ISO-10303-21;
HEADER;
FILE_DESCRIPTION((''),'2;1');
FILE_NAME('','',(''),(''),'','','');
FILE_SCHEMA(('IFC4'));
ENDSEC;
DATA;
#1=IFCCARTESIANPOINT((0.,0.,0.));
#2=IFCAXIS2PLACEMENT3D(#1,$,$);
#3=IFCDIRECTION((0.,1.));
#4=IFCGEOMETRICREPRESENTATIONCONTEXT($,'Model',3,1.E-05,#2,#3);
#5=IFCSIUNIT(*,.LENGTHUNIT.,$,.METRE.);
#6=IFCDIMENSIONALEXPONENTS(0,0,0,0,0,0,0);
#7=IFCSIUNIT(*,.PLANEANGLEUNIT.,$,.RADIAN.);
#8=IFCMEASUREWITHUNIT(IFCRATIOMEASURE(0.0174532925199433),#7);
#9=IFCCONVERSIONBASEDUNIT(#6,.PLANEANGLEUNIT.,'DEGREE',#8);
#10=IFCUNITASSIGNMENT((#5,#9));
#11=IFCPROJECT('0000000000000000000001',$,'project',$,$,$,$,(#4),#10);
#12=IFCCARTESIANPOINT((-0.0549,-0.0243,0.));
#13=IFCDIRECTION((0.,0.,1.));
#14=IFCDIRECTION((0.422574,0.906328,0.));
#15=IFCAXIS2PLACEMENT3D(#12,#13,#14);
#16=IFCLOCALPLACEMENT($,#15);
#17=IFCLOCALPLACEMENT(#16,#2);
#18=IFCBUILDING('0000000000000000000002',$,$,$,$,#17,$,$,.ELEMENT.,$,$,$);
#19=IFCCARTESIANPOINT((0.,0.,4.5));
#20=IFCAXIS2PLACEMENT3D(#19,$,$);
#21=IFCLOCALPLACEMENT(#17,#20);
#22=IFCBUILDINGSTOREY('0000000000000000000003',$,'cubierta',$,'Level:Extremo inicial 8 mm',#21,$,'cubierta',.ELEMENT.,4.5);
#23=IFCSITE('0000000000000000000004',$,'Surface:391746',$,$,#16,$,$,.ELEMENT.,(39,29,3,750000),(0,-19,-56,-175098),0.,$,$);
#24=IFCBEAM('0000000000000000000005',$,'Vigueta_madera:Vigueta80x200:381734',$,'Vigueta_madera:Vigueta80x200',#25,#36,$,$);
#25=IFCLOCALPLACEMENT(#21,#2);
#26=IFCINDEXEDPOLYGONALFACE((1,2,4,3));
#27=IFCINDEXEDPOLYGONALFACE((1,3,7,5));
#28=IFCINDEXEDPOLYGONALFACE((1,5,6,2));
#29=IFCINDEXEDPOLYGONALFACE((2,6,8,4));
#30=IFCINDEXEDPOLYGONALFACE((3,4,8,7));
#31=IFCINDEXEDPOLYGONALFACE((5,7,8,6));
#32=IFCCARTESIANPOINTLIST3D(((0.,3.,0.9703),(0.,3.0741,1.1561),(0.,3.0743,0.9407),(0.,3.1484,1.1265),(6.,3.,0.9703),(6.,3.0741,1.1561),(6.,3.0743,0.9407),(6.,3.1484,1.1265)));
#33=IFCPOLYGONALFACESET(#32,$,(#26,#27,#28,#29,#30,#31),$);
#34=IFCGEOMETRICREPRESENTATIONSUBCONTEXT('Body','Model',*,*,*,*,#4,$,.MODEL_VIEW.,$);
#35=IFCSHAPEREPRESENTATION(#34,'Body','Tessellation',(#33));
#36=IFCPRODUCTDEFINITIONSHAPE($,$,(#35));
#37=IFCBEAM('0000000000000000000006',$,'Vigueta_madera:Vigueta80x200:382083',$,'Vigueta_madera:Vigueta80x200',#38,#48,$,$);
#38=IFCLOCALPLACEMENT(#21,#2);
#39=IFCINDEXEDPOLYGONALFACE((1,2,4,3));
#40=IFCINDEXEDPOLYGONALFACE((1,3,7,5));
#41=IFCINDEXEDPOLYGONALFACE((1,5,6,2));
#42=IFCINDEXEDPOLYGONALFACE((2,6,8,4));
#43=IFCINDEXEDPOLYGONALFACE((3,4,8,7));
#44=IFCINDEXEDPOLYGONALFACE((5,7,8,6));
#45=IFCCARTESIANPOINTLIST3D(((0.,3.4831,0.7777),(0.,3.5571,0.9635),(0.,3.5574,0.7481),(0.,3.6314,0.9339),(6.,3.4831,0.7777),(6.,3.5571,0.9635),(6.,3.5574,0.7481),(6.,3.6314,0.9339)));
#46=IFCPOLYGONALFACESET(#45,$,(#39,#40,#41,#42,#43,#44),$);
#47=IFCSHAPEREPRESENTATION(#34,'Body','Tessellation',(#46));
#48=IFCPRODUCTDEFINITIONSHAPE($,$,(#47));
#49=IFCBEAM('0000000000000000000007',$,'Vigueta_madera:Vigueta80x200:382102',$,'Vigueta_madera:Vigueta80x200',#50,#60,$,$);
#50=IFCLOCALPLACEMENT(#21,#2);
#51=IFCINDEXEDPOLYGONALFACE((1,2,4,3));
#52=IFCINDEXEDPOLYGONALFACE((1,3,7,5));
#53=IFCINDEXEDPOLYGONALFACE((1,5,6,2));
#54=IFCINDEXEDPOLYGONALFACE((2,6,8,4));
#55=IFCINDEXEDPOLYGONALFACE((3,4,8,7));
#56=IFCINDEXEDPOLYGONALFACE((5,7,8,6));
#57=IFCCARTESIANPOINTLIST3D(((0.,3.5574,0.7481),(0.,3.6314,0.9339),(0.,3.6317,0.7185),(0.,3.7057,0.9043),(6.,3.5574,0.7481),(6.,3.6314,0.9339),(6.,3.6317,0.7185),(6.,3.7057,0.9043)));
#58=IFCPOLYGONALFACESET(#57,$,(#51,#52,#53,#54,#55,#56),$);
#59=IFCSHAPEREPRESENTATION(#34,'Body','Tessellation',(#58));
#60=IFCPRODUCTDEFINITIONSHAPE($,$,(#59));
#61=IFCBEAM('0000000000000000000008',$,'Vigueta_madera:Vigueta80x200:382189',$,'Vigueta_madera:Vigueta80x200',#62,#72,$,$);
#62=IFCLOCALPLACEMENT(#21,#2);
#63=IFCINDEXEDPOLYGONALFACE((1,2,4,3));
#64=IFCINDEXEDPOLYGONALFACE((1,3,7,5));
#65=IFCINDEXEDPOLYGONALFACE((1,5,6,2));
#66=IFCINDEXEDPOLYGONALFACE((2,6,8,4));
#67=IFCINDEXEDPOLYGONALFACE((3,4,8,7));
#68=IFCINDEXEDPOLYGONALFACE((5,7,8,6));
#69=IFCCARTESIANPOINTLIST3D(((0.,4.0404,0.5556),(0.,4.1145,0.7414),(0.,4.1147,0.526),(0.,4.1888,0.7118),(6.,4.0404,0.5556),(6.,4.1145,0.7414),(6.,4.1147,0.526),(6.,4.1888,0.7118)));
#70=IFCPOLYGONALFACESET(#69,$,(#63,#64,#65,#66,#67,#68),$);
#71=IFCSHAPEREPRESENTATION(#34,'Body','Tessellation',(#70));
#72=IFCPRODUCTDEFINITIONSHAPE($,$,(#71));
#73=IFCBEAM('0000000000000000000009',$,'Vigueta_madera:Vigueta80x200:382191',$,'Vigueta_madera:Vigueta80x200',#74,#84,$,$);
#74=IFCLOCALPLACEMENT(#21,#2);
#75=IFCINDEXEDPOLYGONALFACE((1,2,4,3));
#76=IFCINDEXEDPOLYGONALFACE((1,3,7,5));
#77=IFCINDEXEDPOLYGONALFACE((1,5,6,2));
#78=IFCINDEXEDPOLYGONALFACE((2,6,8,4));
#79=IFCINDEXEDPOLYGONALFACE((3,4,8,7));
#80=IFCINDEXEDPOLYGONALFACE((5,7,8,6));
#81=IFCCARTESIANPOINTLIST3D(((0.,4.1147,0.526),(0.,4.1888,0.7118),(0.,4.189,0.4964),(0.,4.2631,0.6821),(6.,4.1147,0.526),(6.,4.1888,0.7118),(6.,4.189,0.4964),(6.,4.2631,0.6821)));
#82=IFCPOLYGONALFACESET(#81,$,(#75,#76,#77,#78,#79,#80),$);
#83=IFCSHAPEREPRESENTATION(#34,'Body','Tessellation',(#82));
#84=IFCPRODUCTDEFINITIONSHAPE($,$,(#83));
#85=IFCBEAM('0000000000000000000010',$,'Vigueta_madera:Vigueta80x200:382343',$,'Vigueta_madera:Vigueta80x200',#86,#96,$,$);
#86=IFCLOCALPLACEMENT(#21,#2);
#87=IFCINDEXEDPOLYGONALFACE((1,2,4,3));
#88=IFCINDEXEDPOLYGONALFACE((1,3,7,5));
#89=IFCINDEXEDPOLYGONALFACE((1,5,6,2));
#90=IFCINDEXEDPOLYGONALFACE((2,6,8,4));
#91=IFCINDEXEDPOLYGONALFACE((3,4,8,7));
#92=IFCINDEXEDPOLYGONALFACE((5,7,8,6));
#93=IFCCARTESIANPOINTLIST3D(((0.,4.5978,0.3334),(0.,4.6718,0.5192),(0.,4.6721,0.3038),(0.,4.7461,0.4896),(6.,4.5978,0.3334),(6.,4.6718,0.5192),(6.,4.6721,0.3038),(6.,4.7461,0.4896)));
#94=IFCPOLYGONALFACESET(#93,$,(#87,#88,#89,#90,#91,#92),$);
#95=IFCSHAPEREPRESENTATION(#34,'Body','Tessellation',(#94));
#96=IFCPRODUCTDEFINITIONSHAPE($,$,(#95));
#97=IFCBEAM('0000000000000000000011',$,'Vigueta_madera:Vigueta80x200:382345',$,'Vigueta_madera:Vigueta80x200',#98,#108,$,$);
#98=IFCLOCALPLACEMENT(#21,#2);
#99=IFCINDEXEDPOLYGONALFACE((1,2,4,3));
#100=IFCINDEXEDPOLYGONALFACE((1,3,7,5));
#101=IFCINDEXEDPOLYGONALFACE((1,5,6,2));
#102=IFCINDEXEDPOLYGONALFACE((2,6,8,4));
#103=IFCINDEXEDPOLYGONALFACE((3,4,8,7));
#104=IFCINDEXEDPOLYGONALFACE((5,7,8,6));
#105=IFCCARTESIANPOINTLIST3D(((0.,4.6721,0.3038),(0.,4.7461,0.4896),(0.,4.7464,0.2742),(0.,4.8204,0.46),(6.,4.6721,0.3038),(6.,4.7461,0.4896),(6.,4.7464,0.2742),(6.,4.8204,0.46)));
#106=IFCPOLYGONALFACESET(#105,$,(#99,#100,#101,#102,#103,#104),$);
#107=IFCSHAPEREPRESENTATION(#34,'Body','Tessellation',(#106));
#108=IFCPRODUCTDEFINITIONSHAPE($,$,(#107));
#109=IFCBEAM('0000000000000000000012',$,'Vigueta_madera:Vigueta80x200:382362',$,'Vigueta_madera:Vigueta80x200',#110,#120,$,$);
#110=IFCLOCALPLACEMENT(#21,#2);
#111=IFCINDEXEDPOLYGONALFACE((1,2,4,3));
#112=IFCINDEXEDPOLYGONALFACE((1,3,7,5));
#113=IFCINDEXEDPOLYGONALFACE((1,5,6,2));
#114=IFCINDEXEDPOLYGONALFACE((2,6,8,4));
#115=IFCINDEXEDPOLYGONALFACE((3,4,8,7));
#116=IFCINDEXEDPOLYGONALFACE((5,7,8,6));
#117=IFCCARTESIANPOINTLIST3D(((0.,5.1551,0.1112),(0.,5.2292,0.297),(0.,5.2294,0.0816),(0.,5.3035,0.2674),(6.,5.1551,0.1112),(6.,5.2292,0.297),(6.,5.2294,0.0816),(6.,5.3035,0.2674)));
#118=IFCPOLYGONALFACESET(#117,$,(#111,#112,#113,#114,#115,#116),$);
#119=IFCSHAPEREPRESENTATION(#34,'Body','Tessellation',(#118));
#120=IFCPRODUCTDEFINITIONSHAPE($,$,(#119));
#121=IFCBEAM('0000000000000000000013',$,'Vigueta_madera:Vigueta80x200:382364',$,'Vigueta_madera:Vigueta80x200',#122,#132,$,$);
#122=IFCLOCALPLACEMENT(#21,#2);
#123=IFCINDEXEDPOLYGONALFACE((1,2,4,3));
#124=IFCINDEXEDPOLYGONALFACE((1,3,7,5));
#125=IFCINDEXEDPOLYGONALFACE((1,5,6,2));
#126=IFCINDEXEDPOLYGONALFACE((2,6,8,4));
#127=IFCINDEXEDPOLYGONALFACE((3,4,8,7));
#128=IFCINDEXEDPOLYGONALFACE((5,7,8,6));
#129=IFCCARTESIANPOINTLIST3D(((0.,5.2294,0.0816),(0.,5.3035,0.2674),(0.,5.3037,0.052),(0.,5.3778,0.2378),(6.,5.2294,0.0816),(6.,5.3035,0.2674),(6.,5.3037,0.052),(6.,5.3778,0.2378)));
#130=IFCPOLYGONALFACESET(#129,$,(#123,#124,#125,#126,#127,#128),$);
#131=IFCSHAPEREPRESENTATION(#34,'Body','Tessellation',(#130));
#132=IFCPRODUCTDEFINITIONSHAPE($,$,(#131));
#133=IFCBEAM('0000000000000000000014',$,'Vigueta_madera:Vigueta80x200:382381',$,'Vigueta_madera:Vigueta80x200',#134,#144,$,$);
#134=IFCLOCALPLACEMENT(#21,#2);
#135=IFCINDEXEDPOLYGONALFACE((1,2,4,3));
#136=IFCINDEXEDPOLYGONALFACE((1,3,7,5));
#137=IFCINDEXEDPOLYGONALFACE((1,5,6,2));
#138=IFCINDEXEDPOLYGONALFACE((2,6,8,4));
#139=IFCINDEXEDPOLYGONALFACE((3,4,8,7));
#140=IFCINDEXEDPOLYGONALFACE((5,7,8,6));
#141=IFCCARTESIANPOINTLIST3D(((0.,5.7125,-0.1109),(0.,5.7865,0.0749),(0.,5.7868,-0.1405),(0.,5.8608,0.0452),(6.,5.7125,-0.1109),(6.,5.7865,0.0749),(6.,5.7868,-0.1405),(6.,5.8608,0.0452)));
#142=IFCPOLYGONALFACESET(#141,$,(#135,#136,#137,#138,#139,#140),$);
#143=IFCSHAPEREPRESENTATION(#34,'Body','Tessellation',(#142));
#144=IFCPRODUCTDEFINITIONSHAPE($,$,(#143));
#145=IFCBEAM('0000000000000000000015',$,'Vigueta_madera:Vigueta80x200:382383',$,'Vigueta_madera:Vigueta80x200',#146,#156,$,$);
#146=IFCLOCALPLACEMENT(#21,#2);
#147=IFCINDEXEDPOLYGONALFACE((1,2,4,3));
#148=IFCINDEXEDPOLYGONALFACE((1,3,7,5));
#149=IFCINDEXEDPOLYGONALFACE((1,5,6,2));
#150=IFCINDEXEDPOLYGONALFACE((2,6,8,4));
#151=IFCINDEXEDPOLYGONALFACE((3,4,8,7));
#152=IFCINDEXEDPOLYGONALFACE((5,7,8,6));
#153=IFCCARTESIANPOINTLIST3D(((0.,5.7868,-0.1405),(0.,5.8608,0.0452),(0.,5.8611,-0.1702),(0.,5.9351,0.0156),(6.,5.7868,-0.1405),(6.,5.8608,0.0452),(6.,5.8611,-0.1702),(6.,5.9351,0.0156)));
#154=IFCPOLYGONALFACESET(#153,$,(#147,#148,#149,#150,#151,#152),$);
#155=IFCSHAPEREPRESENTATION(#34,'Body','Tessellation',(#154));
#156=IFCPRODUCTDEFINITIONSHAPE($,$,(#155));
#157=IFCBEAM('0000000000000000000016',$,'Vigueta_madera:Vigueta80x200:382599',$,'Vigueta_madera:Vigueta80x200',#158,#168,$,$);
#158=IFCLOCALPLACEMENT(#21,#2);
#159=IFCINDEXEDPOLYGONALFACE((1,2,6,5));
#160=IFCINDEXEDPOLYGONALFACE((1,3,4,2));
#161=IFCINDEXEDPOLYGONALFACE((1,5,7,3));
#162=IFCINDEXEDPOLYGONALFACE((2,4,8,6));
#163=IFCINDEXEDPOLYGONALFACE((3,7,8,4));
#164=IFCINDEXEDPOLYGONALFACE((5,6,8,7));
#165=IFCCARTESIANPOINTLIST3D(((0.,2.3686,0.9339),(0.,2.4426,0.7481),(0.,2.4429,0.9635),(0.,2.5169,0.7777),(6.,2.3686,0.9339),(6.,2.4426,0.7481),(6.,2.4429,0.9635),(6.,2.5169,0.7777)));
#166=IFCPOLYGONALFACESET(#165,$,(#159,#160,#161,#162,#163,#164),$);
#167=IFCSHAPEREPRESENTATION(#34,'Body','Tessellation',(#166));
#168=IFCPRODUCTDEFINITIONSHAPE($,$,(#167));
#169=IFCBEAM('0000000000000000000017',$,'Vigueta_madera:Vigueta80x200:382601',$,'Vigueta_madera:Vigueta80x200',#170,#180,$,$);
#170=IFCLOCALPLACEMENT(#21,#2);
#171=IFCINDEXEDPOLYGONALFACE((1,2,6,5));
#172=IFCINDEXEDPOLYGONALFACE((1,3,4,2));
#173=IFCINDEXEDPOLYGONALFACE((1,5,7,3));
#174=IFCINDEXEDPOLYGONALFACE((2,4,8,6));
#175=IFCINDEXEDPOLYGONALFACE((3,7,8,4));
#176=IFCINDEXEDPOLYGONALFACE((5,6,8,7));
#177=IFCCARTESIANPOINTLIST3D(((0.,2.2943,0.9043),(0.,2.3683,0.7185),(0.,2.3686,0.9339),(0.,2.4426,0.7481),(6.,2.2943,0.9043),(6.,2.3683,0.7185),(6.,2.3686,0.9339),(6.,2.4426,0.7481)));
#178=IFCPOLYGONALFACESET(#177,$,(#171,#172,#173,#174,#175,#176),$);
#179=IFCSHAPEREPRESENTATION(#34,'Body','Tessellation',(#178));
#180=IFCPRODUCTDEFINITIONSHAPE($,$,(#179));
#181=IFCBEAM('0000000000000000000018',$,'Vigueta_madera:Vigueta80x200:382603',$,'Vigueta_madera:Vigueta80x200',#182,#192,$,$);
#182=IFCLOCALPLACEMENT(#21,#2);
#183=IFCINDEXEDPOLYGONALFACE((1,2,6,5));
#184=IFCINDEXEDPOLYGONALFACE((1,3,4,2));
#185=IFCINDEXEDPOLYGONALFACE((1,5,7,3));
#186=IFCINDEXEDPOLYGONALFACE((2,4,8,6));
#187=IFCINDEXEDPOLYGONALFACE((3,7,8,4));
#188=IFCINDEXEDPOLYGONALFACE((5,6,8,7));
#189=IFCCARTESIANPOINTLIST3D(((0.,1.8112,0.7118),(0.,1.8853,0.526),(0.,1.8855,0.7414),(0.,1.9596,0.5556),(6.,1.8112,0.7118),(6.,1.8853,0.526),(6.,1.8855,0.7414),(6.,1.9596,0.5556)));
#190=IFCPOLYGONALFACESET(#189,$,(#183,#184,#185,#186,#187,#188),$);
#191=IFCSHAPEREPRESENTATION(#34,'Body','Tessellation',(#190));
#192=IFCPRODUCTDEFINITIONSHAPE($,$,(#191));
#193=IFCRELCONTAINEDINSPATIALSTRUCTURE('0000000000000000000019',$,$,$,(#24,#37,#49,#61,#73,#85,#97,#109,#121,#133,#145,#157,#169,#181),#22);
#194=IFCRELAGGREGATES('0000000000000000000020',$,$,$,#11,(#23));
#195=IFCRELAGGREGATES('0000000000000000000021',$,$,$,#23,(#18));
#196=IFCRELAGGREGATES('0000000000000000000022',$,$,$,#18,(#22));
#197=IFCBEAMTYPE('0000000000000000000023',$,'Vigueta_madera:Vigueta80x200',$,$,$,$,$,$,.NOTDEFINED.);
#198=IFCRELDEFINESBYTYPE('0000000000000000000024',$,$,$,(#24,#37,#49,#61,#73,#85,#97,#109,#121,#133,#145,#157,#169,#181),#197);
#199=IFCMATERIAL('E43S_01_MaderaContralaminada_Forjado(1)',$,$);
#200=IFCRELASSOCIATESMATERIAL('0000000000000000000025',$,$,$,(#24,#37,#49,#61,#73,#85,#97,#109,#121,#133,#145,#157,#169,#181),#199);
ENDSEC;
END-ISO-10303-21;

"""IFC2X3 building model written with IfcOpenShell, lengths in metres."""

from ifc_helpers import new_model, entity, si_unit, converted_unit, direction, frame, frame_2d, origin, place, context, subcontext, project, spatial, rectangle, extrude, material, type_object, element, save


model = new_model("IFC2X3")

# Units and contexts
model_context = context("Model", 3, precision=1e-05, world=origin(), true_north=direction((0.0, 1.0)))
body_context = subcontext(model_context, "Body", "Model", "MODEL_VIEW")
ifc_project = project(units=[si_unit("LENGTHUNIT", "METRE"), converted_unit("PLANEANGLEUNIT", "DEGREE", entity("IfcRatioMeasure", 0.0174532925199433), si_unit("PLANEANGLEUNIT", "RADIAN"), dimensions=[0, 0, 0, 0, 0, 0, 0])], contexts=[model_context])

# Site, building, storey
site_placement = place(None, frame((-0.0549, -0.0243, 0.0), z_axis=(0.0, 0.0, 1.0), x_axis=(0.422574, 0.906328, 0.0)))
site = spatial("IfcSite", under=ifc_project, at=site_placement, Name="Surface:391746", CompositionType="ELEMENT", RefLatitude=(39, 29, 3, 750000), RefLongitude=(0, -19, -56, -175098), RefElevation=0.0)
building_placement = place(site_placement, origin())
building = spatial("IfcBuilding", under=site, at=building_placement, CompositionType="ELEMENT")
storey_placement = place(building_placement, frame((0.0, 0.0, 4.5)))
storey = spatial("IfcBuildingStorey", under=building, at=storey_placement, Name="cubierta", ObjectType="Level:Extremo inicial 8 mm", LongName="cubierta", CompositionType="ELEMENT", Elevation=4.5)

# Beams
ifc_material_1 = material(Name="E43S_01_MaderaContralaminada_Forjado(1)")
beam_type = type_object("IfcBeamType", Name="Vigueta_madera:Vigueta80x200", PredefinedType="NOTDEFINED")
beam_1_placement = place(storey_placement, frame((0.0, 3.1112, 1.1413)))
element("IfcBeam", 1, at=beam_1_placement, inside=storey, type_object=beam_type, material=ifc_material_1, Name="Vigueta_madera:Vigueta80x200:381734", ObjectType="Vigueta_madera:Vigueta80x200", context=body_context, shape_type="SweptSolid", body=[
    extrude(rectangle(XDim=0.2, YDim=0.08, at=frame_2d((0.0, 0.0), x_axis=(0.0, 1.0))), frame((0.0, -0.037, -0.0929), z_axis=(1.0, 0.0, 0.0), x_axis=(0.0, -0.928939, 0.370233)), (0.0, 0.0, 1.0), 6.0),
])
beam_2_placement = place(storey_placement, frame((0.0, 3.5943, 0.9487)))
element("IfcBeam", 2, at=beam_2_placement, inside=storey, type_object=beam_type, material=ifc_material_1, Name="Vigueta_madera:Vigueta80x200:382083", ObjectType="Vigueta_madera:Vigueta80x200", context=body_context, shape_type="SweptSolid", body=[
    extrude(rectangle(XDim=0.2, YDim=0.08, at=frame_2d((0.0, 0.0), x_axis=(0.0, 1.0))), frame((0.0, -0.037, -0.0929), z_axis=(1.0, 0.0, 0.0), x_axis=(0.0, -0.928939, 0.370233)), (0.0, 0.0, 1.0), 6.0),
])
for number, where, name in (
    (3, (0.0, 3.6686, 0.9191), "Vigueta_madera:Vigueta80x200:382102"),
    (4, (0.0, 4.1516, 0.7266), "Vigueta_madera:Vigueta80x200:382189"),
):
    element("IfcBeam", number, at=place(storey_placement, frame(where)), inside=storey, type_object=beam_type, material=ifc_material_1, Name=name, ObjectType="Vigueta_madera:Vigueta80x200", context=body_context, shape_type="SweptSolid", body=[
        extrude(rectangle(XDim=0.2, YDim=0.08, at=frame_2d((0.0, 0.0), x_axis=(0.0, 1.0))), frame((0.0, -0.037, -0.0929), z_axis=(1.0, 0.0, 0.0), x_axis=(0.0, -0.928939, 0.370233)), (0.0, 0.0, 1.0), 6.0),
    ])
beam_3_placement = place(storey_placement, frame((0.0, 4.2259, 0.697)))
element("IfcBeam", 5, at=beam_3_placement, inside=storey, type_object=beam_type, material=ifc_material_1, Name="Vigueta_madera:Vigueta80x200:382191", ObjectType="Vigueta_madera:Vigueta80x200", context=body_context, shape_type="SweptSolid", body=[
    extrude(rectangle(XDim=0.2, YDim=0.08, at=frame_2d((0.0, 0.0), x_axis=(0.0, 1.0))), frame((0.0, -0.037, -0.0929), z_axis=(1.0, 0.0, 0.0), x_axis=(0.0, -0.928939, 0.370233)), (0.0, 0.0, 1.0), 6.0),
])
for number, where, name in (
    (6, (0.0, 4.709, 0.5044), "Vigueta_madera:Vigueta80x200:382343"),
    (7, (0.0, 4.7833, 0.4748), "Vigueta_madera:Vigueta80x200:382345"),
):
    element("IfcBeam", number, at=place(storey_placement, frame(where)), inside=storey, type_object=beam_type, material=ifc_material_1, Name=name, ObjectType="Vigueta_madera:Vigueta80x200", context=body_context, shape_type="SweptSolid", body=[
        extrude(rectangle(XDim=0.2, YDim=0.08, at=frame_2d((0.0, 0.0), x_axis=(0.0, 1.0))), frame((0.0, -0.037, -0.0929), z_axis=(1.0, 0.0, 0.0), x_axis=(0.0, -0.928939, 0.370233)), (0.0, 0.0, 1.0), 6.0),
    ])
beam_4_placement = place(storey_placement, frame((0.0, 5.2663, 0.2822)))
element("IfcBeam", 8, at=beam_4_placement, inside=storey, type_object=beam_type, material=ifc_material_1, Name="Vigueta_madera:Vigueta80x200:382362", ObjectType="Vigueta_madera:Vigueta80x200", context=body_context, shape_type="SweptSolid", body=[
    extrude(rectangle(XDim=0.2, YDim=0.08, at=frame_2d((0.0, 0.0), x_axis=(0.0, 1.0))), frame((0.0, -0.037, -0.0929), z_axis=(1.0, 0.0, 0.0), x_axis=(0.0, -0.928939, 0.370233)), (0.0, 0.0, 1.0), 6.0),
])
for number, where, name in (
    (9, (0.0, 5.3406, 0.2526), "Vigueta_madera:Vigueta80x200:382364"),
    (10, (0.0, 5.8237, 0.0601), "Vigueta_madera:Vigueta80x200:382381"),
):
    element("IfcBeam", number, at=place(storey_placement, frame(where)), inside=storey, type_object=beam_type, material=ifc_material_1, Name=name, ObjectType="Vigueta_madera:Vigueta80x200", context=body_context, shape_type="SweptSolid", body=[
        extrude(rectangle(XDim=0.2, YDim=0.08, at=frame_2d((0.0, 0.0), x_axis=(0.0, 1.0))), frame((0.0, -0.037, -0.0929), z_axis=(1.0, 0.0, 0.0), x_axis=(0.0, -0.928939, 0.370233)), (0.0, 0.0, 1.0), 6.0),
    ])
beam_5_placement = place(storey_placement, frame((0.0, 5.898, 0.0304)))
element("IfcBeam", 11, at=beam_5_placement, inside=storey, type_object=beam_type, material=ifc_material_1, Name="Vigueta_madera:Vigueta80x200:382383", ObjectType="Vigueta_madera:Vigueta80x200", context=body_context, shape_type="SweptSolid", body=[
    extrude(rectangle(XDim=0.2, YDim=0.08, at=frame_2d((0.0, 0.0), x_axis=(0.0, 1.0))), frame((0.0, -0.037, -0.0929), z_axis=(1.0, 0.0, 0.0), x_axis=(0.0, -0.928939, 0.370233)), (0.0, 0.0, 1.0), 6.0),
])
beam_6_placement = place(storey_placement, frame((0.0, 2.4057, 0.9487)))
element("IfcBeam", 12, at=beam_6_placement, inside=storey, type_object=beam_type, material=ifc_material_1, Name="Vigueta_madera:Vigueta80x200:382599", ObjectType="Vigueta_madera:Vigueta80x200", context=body_context, shape_type="SweptSolid", body=[
    extrude(rectangle(XDim=0.2, YDim=0.08, at=frame_2d((0.0, 0.0), x_axis=(1.0, 0.0))), frame((0.0, 0.037, -0.0929), z_axis=(1.0, 0.0, 0.0), x_axis=(0.0, -0.370233, 0.928939)), (0.0, 0.0, 1.0), 6.0),
])
beam_7_placement = place(storey_placement, frame((0.0, 2.3314, 0.9191)))
element("IfcBeam", 13, at=beam_7_placement, inside=storey, type_object=beam_type, material=ifc_material_1, Name="Vigueta_madera:Vigueta80x200:382601", ObjectType="Vigueta_madera:Vigueta80x200", context=body_context, shape_type="SweptSolid", body=[
    extrude(rectangle(XDim=0.2, YDim=0.08, at=frame_2d((0.0, 0.0), x_axis=(1.0, 0.0))), frame((0.0, 0.037, -0.0929), z_axis=(1.0, 0.0, 0.0), x_axis=(0.0, -0.370233, 0.928939)), (0.0, 0.0, 1.0), 6.0),
])
beam_8_placement = place(storey_placement, frame((0.0, 1.8484, 0.7266)))
element("IfcBeam", 14, at=beam_8_placement, inside=storey, type_object=beam_type, material=ifc_material_1, Name="Vigueta_madera:Vigueta80x200:382603", ObjectType="Vigueta_madera:Vigueta80x200", context=body_context, shape_type="SweptSolid", body=[
    extrude(rectangle(XDim=0.2, YDim=0.08, at=frame_2d((0.0, 0.0), x_axis=(1.0, 0.0))), frame((0.0, 0.037, -0.0929), z_axis=(1.0, 0.0, 0.0), x_axis=(0.0, -0.370233, 0.928939)), (0.0, 0.0, 1.0), 6.0),
])

save(model, "model.ifc")
